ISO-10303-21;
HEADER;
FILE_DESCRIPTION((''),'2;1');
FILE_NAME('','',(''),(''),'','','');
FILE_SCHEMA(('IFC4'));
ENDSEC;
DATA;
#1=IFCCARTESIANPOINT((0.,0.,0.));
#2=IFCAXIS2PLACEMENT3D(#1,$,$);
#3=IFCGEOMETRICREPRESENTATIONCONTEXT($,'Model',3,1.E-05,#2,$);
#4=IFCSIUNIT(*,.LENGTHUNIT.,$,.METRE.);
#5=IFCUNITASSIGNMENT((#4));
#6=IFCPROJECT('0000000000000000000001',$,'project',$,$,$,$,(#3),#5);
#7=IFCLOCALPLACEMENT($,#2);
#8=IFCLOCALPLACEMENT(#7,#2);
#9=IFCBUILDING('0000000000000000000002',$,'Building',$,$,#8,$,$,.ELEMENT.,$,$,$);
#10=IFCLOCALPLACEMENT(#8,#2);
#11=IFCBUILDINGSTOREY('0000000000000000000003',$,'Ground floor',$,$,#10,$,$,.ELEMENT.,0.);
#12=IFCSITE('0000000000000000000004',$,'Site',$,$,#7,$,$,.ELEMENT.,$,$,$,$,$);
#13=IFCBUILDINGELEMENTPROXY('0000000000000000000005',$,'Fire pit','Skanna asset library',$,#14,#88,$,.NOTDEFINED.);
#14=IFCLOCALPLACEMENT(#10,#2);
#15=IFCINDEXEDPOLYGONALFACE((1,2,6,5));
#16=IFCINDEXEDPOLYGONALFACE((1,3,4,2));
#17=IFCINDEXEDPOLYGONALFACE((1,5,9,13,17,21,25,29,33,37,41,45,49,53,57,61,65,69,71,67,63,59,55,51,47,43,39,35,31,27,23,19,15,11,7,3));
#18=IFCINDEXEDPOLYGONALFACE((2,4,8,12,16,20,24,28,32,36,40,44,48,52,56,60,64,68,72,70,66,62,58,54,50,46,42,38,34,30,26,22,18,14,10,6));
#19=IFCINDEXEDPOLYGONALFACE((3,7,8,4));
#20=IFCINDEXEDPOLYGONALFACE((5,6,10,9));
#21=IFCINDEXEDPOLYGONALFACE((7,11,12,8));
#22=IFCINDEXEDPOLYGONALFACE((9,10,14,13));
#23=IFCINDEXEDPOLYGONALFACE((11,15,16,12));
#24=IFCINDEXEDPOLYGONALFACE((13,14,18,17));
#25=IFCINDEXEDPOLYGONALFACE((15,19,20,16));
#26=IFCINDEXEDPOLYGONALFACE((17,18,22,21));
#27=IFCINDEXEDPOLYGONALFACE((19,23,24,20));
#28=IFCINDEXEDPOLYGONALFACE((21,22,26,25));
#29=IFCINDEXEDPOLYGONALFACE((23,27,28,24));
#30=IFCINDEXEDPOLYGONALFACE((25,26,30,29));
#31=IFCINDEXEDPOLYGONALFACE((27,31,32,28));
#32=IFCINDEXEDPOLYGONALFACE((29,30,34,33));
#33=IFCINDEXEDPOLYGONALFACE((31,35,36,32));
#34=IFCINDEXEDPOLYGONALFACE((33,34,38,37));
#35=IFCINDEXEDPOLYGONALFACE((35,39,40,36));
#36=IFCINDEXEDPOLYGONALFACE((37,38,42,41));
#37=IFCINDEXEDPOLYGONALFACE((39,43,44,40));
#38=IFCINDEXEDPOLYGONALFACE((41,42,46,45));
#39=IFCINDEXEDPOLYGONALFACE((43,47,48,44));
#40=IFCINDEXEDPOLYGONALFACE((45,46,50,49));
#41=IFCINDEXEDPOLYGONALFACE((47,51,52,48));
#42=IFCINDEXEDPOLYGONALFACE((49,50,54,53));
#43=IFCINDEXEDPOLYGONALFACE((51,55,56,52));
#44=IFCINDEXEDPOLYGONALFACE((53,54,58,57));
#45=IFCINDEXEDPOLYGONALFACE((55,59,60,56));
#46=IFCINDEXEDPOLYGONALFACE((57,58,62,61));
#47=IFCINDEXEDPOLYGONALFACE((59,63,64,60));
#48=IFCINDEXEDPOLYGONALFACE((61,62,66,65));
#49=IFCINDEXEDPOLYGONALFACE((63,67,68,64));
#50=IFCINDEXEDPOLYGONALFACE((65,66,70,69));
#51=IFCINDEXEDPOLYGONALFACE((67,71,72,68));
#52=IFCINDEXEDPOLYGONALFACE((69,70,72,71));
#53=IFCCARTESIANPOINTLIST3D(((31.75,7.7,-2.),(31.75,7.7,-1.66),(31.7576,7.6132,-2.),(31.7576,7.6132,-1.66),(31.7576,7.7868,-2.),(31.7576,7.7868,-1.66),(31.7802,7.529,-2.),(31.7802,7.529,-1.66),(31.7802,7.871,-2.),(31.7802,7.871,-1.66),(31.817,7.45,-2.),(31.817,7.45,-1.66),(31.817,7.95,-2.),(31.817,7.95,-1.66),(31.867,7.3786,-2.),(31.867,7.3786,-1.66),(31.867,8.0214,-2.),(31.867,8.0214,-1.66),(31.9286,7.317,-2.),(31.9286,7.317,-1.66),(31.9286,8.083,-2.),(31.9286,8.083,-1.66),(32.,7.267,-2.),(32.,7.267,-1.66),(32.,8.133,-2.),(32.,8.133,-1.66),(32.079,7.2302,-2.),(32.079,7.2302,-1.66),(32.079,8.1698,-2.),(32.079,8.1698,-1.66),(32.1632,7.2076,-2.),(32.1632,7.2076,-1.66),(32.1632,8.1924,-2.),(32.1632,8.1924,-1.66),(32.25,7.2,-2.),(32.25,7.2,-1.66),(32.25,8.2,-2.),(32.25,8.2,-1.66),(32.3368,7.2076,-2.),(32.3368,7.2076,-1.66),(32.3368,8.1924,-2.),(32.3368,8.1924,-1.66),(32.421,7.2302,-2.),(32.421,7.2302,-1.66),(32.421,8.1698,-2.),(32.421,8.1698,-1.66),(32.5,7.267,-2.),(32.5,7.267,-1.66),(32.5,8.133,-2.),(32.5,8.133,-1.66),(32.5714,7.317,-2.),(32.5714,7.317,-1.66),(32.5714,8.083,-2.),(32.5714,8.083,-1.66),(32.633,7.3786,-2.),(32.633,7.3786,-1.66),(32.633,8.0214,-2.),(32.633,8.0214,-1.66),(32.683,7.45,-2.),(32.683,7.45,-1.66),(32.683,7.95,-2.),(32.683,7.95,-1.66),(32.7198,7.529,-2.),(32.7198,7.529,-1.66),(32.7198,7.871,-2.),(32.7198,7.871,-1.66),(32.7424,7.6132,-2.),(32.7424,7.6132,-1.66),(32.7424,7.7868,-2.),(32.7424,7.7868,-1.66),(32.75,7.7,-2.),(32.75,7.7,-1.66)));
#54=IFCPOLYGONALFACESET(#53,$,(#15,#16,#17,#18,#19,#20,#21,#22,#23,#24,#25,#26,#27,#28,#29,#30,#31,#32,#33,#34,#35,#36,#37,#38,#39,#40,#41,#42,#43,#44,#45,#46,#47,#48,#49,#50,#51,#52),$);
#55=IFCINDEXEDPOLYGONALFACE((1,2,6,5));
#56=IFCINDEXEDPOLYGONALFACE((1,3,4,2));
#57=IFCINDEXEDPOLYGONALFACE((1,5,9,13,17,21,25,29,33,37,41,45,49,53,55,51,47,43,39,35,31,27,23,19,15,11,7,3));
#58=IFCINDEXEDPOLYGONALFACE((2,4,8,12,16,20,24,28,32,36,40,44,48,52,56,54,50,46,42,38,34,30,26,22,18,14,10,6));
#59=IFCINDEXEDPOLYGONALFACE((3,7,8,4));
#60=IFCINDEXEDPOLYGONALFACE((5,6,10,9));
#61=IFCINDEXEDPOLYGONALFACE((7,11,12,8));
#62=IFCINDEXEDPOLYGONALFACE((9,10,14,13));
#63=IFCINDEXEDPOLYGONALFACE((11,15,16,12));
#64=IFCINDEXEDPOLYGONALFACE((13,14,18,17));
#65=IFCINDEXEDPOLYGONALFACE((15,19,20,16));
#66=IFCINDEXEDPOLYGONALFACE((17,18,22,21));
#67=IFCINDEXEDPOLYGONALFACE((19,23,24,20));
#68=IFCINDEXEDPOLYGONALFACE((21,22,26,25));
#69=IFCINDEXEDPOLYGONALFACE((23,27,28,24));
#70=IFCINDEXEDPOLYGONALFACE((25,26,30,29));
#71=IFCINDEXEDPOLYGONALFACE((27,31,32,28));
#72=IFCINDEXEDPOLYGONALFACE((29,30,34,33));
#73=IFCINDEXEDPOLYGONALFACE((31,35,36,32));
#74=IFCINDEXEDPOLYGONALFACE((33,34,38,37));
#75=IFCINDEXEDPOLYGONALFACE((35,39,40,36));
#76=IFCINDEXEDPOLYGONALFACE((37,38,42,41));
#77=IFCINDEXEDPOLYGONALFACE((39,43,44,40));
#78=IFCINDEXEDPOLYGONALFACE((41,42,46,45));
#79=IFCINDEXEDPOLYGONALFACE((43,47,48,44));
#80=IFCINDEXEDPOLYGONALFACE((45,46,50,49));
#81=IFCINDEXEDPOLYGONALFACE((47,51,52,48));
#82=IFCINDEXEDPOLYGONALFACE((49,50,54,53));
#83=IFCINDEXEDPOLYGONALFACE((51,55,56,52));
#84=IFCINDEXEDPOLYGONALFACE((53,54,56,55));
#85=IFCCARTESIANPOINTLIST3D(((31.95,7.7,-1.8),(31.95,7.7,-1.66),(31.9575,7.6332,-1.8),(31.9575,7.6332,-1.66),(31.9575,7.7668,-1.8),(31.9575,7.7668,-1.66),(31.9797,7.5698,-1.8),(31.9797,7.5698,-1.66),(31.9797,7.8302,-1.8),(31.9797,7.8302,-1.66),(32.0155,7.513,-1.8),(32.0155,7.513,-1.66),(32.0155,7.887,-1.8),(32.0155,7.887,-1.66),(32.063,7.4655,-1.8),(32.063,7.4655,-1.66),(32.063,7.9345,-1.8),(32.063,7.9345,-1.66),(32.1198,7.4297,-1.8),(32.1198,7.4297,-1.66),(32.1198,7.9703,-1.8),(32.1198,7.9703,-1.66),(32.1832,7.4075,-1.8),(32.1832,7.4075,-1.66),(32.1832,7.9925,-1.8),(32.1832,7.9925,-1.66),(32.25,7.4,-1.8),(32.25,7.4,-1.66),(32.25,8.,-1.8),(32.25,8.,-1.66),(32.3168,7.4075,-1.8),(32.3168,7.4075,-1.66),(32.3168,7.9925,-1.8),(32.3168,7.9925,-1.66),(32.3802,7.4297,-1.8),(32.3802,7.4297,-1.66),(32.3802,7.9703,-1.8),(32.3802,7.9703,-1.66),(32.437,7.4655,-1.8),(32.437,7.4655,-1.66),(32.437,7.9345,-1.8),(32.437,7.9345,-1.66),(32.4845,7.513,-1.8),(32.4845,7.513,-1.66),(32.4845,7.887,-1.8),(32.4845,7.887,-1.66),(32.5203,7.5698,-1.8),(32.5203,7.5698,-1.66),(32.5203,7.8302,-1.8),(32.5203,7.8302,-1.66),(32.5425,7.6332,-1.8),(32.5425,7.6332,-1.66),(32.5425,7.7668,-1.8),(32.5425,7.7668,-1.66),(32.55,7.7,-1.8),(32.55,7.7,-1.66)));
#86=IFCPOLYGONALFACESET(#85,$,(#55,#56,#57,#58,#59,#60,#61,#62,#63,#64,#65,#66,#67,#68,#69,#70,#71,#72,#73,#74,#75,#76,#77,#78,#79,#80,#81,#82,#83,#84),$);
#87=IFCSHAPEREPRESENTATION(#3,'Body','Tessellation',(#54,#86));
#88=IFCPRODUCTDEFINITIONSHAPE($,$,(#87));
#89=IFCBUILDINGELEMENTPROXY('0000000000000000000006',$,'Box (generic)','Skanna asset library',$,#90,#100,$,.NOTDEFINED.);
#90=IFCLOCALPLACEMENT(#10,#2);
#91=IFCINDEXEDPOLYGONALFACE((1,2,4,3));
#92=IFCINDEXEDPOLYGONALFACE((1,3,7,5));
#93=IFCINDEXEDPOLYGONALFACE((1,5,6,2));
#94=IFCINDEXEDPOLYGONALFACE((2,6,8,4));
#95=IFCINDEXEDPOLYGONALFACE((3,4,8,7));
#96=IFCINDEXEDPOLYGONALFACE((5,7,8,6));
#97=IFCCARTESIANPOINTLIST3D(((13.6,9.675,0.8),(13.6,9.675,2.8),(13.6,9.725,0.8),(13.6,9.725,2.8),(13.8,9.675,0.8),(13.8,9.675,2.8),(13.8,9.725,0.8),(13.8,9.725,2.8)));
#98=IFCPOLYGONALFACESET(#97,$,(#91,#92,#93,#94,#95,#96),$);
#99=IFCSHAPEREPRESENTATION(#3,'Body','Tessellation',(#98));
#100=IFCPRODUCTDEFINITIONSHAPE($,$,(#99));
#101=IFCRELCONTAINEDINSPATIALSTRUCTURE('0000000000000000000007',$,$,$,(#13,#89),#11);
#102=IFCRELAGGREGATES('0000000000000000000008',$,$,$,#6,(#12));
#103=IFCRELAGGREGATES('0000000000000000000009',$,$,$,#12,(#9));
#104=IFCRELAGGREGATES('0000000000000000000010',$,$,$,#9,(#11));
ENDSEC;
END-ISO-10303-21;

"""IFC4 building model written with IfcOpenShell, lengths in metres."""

from ifc_helpers import new_model, si_unit, frame, origin, origin_2d, place, context, project, spatial, rectangle, circle, extrude, element, save


model = new_model("IFC4")

# Units and contexts
model_context = context("Model", 3, precision=1e-05, world=origin())
ifc_project = project(units=[si_unit("LENGTHUNIT", "METRE")], contexts=[model_context])

# Site, building, storey
site_placement = place(None, origin())
site = spatial("IfcSite", under=ifc_project, at=site_placement, Name="Site", CompositionType="ELEMENT")
building_placement = place(site_placement, origin())
building = spatial("IfcBuilding", under=site, at=building_placement, Name="Building", CompositionType="ELEMENT")
storey_placement = place(building_placement, origin())
storey = spatial("IfcBuildingStorey", under=building, at=storey_placement, Name="Ground floor", CompositionType="ELEMENT", Elevation=0.0)

# Building element proxies
proxy_1_placement = place(storey_placement, frame((32.25, 7.7, -2.0), z_axis=(0.0, 0.0, 1.0), x_axis=(1.0, 0.0, 0.0)))
element("IfcBuildingElementProxy", 1, at=proxy_1_placement, inside=storey, Name="Fire pit", Description="Skanna asset library", PredefinedType="NOTDEFINED", context=model_context, shape_type="SweptSolid", body=[
    extrude(circle(Radius=0.5, at=origin_2d()), origin(), (0.0, 0.0, 1.0), 0.34),
    extrude(circle(Radius=0.3, at=origin_2d()), frame((0.0, 0.0, 0.2)), (0.0, 0.0, 1.0), 0.14),
])
proxy_2_placement = place(storey_placement, frame((13.7, 9.7, 0.8), z_axis=(0.0, 0.0, 1.0), x_axis=(1.0, 0.0, 0.0)))
element("IfcBuildingElementProxy", 2, at=proxy_2_placement, inside=storey, Name="Box (generic)", Description="Skanna asset library", PredefinedType="NOTDEFINED", context=model_context, shape_type="SweptSolid", body=[
    extrude(rectangle(XDim=0.2, YDim=0.05, at=origin_2d()), origin(), (0.0, 0.0, 1.0), 2.0),
])

save(model, "model.ifc")
